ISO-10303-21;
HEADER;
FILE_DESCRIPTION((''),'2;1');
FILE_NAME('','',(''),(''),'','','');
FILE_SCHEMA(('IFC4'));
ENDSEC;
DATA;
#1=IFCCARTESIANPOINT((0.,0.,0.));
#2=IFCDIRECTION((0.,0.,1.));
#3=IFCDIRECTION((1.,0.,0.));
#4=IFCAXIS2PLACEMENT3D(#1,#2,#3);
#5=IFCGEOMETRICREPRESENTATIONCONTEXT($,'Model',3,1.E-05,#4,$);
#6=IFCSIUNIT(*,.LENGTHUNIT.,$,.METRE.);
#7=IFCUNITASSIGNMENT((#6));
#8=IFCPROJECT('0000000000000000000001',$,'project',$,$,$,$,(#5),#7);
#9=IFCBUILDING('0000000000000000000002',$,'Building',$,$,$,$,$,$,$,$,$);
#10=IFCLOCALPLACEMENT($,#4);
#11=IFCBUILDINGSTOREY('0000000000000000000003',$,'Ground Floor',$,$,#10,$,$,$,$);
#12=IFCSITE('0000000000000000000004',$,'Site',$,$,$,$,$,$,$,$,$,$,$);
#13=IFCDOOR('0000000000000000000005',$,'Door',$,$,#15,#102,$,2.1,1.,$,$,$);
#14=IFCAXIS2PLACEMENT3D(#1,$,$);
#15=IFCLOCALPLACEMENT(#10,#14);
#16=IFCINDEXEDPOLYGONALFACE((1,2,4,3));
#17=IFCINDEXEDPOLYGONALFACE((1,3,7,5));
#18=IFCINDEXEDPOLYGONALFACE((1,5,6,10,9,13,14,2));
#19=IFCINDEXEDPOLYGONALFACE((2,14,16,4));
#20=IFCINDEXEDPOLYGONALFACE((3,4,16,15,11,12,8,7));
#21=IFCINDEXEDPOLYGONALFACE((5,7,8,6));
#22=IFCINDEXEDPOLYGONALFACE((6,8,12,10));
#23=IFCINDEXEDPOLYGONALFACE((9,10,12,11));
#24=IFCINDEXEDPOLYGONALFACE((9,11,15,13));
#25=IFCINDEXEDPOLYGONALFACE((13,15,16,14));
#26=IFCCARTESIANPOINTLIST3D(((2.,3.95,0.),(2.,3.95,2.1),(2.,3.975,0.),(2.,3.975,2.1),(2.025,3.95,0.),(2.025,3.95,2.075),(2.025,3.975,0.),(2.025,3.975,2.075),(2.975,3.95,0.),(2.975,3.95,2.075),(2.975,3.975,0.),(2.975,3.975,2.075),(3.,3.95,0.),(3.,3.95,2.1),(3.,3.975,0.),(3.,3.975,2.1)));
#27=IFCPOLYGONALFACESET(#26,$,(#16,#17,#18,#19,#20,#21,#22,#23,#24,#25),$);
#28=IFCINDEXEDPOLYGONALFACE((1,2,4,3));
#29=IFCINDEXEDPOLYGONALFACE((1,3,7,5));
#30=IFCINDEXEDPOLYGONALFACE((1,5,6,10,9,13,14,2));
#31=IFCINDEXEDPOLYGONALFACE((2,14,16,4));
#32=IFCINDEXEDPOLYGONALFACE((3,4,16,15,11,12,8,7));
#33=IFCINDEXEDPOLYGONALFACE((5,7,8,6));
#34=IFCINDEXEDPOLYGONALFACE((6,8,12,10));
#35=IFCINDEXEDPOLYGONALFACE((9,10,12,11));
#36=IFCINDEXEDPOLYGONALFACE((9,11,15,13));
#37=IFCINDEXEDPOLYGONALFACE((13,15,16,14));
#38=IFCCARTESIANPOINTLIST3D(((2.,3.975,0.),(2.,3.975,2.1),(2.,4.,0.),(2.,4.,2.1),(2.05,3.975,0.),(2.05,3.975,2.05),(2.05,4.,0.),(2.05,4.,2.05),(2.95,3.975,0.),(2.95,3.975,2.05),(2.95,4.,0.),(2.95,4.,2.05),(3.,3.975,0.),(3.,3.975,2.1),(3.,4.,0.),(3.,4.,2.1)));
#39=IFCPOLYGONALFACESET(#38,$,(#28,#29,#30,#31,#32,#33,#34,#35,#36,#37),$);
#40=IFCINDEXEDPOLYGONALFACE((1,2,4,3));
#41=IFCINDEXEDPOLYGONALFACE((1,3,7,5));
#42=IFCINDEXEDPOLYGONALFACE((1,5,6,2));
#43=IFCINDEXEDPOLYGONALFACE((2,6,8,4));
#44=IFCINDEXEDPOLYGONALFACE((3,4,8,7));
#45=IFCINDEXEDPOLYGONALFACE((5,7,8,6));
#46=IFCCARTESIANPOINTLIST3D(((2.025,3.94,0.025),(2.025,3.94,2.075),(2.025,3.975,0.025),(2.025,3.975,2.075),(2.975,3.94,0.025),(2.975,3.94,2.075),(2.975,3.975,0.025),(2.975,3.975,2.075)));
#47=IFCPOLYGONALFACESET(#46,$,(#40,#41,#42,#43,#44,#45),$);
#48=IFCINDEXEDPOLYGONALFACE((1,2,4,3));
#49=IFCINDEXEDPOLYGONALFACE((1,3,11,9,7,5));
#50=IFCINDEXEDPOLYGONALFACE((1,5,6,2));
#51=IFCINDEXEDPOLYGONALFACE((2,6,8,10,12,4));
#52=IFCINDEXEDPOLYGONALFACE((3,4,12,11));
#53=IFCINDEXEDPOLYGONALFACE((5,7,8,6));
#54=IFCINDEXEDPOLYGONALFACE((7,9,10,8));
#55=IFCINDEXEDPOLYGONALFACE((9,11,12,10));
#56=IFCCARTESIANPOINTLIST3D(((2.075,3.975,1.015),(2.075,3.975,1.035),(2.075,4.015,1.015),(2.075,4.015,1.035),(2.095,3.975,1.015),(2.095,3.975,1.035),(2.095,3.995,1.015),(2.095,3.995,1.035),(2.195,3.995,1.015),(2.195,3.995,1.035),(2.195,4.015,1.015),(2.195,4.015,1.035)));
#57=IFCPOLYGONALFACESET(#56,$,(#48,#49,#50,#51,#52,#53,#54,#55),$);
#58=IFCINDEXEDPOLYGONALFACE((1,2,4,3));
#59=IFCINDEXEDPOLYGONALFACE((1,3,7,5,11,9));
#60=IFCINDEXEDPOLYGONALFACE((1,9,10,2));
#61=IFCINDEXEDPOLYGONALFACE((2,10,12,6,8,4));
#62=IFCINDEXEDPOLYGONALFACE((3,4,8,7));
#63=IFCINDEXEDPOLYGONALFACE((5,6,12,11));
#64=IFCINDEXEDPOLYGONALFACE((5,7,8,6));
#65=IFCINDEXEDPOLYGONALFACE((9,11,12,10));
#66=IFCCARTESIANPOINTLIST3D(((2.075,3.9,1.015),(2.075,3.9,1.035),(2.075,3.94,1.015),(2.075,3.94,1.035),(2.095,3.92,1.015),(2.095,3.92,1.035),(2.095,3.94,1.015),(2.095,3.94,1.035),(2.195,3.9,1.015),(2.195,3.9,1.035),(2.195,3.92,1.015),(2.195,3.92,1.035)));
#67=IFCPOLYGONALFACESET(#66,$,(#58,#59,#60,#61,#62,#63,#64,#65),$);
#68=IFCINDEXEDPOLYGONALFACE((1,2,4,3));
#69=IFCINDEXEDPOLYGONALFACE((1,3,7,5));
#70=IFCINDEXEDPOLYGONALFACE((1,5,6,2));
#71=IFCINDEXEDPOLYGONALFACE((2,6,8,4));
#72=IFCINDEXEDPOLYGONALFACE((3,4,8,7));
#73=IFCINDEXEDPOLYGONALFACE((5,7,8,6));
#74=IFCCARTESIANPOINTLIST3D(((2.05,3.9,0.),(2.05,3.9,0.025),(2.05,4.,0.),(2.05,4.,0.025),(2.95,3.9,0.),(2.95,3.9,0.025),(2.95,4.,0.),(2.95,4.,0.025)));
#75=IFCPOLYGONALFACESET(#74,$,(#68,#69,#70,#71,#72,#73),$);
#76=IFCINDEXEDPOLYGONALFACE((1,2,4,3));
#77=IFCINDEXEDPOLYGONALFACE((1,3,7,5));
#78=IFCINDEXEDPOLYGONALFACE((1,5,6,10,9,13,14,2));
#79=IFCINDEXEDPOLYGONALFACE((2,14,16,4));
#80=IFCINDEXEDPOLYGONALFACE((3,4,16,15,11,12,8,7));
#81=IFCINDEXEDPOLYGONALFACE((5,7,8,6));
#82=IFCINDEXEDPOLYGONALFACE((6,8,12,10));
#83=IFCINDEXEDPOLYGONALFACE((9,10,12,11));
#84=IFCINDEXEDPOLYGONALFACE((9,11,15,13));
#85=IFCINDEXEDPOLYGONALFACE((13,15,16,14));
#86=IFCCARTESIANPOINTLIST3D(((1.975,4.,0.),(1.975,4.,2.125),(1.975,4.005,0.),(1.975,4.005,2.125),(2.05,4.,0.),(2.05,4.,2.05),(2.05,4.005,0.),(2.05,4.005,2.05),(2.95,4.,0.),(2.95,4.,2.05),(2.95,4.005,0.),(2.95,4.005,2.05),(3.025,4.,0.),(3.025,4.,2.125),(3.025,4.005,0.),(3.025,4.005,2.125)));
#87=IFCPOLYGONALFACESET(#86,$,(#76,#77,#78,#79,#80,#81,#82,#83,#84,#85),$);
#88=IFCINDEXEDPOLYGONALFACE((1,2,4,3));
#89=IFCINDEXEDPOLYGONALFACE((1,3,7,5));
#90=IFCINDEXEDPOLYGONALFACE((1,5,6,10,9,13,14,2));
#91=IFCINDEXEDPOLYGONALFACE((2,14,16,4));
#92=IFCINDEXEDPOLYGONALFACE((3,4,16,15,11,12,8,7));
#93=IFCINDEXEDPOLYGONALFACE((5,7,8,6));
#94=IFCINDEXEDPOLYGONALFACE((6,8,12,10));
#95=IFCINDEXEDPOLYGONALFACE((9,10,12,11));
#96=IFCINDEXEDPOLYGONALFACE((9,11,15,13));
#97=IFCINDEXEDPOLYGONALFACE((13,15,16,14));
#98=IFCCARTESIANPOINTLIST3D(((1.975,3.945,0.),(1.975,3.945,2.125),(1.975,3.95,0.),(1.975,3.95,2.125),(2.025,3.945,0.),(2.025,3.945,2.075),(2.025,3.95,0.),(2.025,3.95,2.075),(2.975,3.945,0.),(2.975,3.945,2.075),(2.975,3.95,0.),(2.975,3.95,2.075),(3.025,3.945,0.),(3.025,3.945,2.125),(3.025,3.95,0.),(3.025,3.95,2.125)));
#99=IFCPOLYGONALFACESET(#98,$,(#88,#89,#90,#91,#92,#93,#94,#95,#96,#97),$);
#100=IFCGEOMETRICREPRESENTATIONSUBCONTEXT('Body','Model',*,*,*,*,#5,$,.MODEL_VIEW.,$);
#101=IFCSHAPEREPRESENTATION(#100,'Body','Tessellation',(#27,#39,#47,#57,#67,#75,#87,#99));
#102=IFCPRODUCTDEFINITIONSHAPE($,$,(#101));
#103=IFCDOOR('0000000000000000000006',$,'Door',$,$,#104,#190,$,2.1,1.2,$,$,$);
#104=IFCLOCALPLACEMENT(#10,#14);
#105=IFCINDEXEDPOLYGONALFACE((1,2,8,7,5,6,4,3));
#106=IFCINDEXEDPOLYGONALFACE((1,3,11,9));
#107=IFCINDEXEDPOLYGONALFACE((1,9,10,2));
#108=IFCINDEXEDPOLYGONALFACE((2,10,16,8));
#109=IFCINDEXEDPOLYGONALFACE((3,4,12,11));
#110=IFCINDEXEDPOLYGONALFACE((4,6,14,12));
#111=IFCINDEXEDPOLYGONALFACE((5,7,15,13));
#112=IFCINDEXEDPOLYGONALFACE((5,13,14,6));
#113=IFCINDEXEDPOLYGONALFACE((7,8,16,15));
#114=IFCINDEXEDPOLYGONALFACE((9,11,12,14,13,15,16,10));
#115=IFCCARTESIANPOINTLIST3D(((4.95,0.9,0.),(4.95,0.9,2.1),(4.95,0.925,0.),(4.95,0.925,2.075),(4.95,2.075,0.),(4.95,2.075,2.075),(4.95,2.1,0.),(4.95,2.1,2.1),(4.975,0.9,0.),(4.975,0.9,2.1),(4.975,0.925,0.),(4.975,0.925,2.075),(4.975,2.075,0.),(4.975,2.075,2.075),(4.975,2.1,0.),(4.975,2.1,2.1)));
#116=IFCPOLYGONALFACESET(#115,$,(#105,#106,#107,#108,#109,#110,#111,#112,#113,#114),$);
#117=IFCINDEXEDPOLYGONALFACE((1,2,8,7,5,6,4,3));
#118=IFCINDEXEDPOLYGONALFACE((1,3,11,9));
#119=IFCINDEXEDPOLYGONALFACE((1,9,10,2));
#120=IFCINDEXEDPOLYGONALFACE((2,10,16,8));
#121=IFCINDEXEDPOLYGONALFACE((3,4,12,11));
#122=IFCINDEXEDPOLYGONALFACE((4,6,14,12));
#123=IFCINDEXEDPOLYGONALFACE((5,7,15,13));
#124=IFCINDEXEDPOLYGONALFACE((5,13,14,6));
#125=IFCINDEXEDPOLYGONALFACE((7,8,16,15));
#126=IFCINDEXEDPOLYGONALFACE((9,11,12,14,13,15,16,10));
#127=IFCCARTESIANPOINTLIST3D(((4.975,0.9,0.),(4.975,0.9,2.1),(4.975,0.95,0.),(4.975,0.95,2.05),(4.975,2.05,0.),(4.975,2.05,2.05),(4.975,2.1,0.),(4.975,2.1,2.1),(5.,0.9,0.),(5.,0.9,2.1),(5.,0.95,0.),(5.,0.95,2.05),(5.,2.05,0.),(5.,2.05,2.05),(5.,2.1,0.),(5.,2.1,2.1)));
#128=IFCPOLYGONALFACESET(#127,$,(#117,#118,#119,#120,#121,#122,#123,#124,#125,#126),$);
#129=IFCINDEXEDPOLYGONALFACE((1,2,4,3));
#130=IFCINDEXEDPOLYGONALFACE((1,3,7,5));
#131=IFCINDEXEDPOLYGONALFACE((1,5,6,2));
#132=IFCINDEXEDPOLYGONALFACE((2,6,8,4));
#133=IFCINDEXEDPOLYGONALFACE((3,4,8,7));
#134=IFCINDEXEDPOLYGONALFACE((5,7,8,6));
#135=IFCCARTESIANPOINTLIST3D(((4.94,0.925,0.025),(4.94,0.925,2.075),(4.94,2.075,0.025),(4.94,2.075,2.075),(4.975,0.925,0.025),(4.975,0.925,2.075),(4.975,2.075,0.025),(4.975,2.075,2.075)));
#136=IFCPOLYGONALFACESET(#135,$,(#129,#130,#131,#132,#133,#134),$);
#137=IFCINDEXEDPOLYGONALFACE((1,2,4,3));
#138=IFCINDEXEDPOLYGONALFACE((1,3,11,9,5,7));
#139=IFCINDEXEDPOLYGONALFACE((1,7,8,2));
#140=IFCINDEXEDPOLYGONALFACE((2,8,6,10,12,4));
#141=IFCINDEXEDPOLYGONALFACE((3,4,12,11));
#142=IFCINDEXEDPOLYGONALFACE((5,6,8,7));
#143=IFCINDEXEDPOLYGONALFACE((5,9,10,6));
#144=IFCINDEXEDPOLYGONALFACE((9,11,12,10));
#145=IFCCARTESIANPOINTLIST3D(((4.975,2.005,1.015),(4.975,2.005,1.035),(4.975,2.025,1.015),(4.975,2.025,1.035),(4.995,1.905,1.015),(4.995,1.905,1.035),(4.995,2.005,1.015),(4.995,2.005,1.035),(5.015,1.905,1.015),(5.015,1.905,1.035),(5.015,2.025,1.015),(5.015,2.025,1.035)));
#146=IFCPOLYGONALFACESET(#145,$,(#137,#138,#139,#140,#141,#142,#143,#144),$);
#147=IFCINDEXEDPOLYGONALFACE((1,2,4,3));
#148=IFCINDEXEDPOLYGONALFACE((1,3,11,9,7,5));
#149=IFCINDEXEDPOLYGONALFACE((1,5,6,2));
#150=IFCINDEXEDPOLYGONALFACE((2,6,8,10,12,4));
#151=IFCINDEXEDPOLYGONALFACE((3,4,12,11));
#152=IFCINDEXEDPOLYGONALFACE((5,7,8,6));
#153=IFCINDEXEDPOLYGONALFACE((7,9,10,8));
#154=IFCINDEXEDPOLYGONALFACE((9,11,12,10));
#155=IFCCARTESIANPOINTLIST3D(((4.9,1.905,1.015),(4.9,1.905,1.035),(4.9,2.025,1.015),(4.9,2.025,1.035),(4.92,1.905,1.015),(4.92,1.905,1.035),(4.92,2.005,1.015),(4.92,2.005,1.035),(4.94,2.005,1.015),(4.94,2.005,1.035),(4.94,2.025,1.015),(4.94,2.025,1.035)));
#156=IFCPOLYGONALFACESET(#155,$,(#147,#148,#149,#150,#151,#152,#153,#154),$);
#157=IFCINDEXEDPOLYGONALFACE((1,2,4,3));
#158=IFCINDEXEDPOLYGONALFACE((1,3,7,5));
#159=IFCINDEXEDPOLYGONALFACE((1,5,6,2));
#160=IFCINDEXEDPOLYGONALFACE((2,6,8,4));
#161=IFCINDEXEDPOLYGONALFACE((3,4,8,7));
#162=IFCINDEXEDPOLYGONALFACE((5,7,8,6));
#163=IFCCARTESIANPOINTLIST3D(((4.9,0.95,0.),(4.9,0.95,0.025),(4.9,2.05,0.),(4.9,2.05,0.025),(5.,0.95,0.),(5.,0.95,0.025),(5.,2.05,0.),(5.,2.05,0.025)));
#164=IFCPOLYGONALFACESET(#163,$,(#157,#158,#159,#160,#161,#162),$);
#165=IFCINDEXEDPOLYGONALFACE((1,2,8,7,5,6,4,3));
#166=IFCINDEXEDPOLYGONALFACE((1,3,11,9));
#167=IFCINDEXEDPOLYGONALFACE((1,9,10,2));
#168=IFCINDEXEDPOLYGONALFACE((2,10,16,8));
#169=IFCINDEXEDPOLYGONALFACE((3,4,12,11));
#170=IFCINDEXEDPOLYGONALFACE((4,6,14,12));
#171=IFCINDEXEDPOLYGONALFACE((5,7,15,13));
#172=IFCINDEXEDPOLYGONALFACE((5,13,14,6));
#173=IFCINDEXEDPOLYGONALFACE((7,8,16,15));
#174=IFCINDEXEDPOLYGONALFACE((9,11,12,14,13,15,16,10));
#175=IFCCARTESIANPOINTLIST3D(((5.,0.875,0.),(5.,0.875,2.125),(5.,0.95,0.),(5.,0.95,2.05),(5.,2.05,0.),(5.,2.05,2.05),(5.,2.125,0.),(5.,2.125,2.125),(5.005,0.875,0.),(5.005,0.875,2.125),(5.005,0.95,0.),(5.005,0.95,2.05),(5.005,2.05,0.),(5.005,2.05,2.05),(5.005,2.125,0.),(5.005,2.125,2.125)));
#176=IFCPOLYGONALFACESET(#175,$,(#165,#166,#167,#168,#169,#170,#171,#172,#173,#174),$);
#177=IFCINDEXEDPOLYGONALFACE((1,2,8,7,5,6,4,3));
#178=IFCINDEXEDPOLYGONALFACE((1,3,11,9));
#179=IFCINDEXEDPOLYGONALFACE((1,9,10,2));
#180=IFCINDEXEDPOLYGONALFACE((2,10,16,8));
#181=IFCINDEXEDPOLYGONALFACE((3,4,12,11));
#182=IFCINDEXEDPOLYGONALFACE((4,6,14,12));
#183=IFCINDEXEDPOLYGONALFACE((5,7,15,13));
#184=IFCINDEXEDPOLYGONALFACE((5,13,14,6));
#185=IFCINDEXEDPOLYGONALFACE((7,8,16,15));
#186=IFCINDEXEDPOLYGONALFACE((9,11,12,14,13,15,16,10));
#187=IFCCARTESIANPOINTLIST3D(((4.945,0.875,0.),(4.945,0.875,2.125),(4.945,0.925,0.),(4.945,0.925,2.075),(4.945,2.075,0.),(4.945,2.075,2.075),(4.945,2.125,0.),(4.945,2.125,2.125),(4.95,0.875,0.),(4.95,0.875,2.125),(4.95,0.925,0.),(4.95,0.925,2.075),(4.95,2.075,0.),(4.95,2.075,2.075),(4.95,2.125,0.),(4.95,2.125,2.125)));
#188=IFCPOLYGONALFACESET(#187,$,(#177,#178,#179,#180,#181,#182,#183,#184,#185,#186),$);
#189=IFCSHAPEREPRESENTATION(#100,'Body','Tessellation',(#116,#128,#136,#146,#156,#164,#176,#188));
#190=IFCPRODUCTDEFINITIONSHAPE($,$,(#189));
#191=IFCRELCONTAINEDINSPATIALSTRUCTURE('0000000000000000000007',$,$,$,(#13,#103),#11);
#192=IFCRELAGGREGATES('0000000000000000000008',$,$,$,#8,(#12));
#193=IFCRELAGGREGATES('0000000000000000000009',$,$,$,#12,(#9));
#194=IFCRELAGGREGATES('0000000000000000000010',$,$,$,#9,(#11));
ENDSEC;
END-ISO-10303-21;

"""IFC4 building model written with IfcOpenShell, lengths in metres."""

from ifc_helpers import new_model, si_unit, frame, origin_with_axes, place, context, subcontext, project, spatial, line, indexed_curve, outline, extrude, element, save


model = new_model("IFC4")

# Units and contexts
model_context = context("Model", 3, precision=1e-05, world=origin_with_axes())
body_context = subcontext(model_context, "Body", "Model", "MODEL_VIEW")
ifc_project = project(units=[si_unit("LENGTHUNIT", "METRE")], contexts=[model_context])

# Site, building, storey
site = spatial("IfcSite", under=ifc_project, Name="Site")
building = spatial("IfcBuilding", under=site, Name="Building")
storey_placement = place(None, origin_with_axes())
storey = spatial("IfcBuildingStorey", under=building, at=storey_placement, Name="Ground Floor")

# Doors
door_1_placement = place(storey_placement, frame((3.0, 4.0, 0.0), z_axis=(0.0, 0.0, 1.0), x_axis=(-1.0, 0.0, 0.0)))
element("IfcDoor", 1, at=door_1_placement, inside=storey, Name="Door", OverallHeight=2.1, OverallWidth=1.0, context=body_context, shape_type="SweptSolid", body=[
    extrude(outline(indexed_curve([(0.0, 0.0), (0.0, 2.1), (1.0, 2.1), (1.0, 0.0), (0.975, 0.0), (0.975, 2.075), (0.025, 2.075), (0.025, 0.0)], segments=[line(1, 2, 3, 4, 5, 6, 7, 8, 1)])), frame((0.0, 0.025, 0.0), z_axis=(0.0, -1.0, 0.0), x_axis=(1.0, 0.0, 0.0)), (0.0, 0.0, -1.0), 0.025),
    extrude(outline(indexed_curve([(0.0, 0.0), (0.0, 2.1), (1.0, 2.1), (1.0, 0.0), (0.95, 0.0), (0.95, 2.05), (0.05, 2.05), (0.05, 0.0)], segments=[line(1, 2, 3, 4, 5, 6, 7, 8, 1)])), frame((0.0, 0.0, 0.0), z_axis=(0.0, -1.0, 0.0), x_axis=(1.0, 0.0, 0.0)), (0.0, 0.0, -1.0), 0.025),
    extrude(outline(indexed_curve([(0.0, 0.0), (0.95, 0.0), (0.95, 0.035), (0.0, 0.035)], segments=[line(1, 2, 3, 4, 1)])), frame((0.025, 0.025, 0.025), z_axis=(0.0, 0.0, 1.0), x_axis=(1.0, 0.0, 0.0)), (0.0, 0.0, 1.0), 2.05),
    extrude(outline(indexed_curve([(0.0, 0.0), (0.0, -0.04), (-0.12, -0.04), (-0.12, -0.02), (-0.02, -0.02), (-0.02, 0.0)], segments=[line(1, 2, 3, 4, 5, 6, 1)])), frame((0.925, 0.025, 1.015), z_axis=(0.0, 0.0, 1.0), x_axis=(1.0, 0.0, 0.0)), (0.0, 0.0, 1.0), 0.02),
    extrude(outline(indexed_curve([(0.0, 0.0), (0.0, 0.04), (-0.12, 0.04), (-0.12, 0.02), (-0.02, 0.02), (-0.02, 0.0)], segments=[line(1, 2, 3, 4, 5, 6, 1)])), frame((0.925, 0.06, 1.015), z_axis=(0.0, 0.0, 1.0), x_axis=(1.0, 0.0, 0.0)), (0.0, 0.0, 1.0), 0.02),
    extrude(outline(indexed_curve([(0.0, 0.0), (0.9, 0.0), (0.9, 0.1), (0.0, 0.1)], segments=[line(1, 2, 3, 4, 1)])), frame((0.05, 0.0, 0.0), z_axis=(0.0, 0.0, 1.0), x_axis=(1.0, 0.0, 0.0)), (0.0, 0.0, 1.0), 0.025),
    extrude(outline(indexed_curve([(0.0, 0.0), (0.0, 2.125), (1.05, 2.125), (1.05, 0.0), (0.975, 0.0), (0.975, 2.05), (0.075, 2.05), (0.075, 0.0)], segments=[line(1, 2, 3, 4, 5, 6, 7, 8, 1)])), frame((-0.025, -0.005, 0.0), z_axis=(0.0, -1.0, 0.0), x_axis=(1.0, 0.0, 0.0)), (0.0, 0.0, -1.0), 0.005),
    extrude(outline(indexed_curve([(0.0, 0.0), (0.0, 2.125), (1.05, 2.125), (1.05, 0.0), (1.0, 0.0), (1.0, 2.075), (0.05, 2.075), (0.05, 0.0)], segments=[line(1, 2, 3, 4, 5, 6, 7, 8, 1)])), frame((-0.025, 0.05, 0.0), z_axis=(0.0, -1.0, 0.0), x_axis=(1.0, 0.0, 0.0)), (0.0, 0.0, -1.0), 0.005),
])
door_2_placement = place(storey_placement, frame((5.0, 0.9, 0.0), z_axis=(0.0, 0.0, 1.0), x_axis=(0.0, 1.0, 0.0)))
element("IfcDoor", 2, at=door_2_placement, inside=storey, Name="Door", OverallHeight=2.1, OverallWidth=1.2, context=body_context, shape_type="SweptSolid", body=[
    extrude(outline(indexed_curve([(0.0, 0.0), (0.0, 2.1), (1.2, 2.1), (1.2, 0.0), (1.175, 0.0), (1.175, 2.075), (0.025, 2.075), (0.025, 0.0)], segments=[line(1, 2, 3, 4, 5, 6, 7, 8, 1)])), frame((0.0, 0.025, 0.0), z_axis=(0.0, -1.0, 0.0), x_axis=(1.0, 0.0, 0.0)), (0.0, 0.0, -1.0), 0.025),
    extrude(outline(indexed_curve([(0.0, 0.0), (0.0, 2.1), (1.2, 2.1), (1.2, 0.0), (1.15, 0.0), (1.15, 2.05), (0.05, 2.05), (0.05, 0.0)], segments=[line(1, 2, 3, 4, 5, 6, 7, 8, 1)])), frame((0.0, 0.0, 0.0), z_axis=(0.0, -1.0, 0.0), x_axis=(1.0, 0.0, 0.0)), (0.0, 0.0, -1.0), 0.025),
    extrude(outline(indexed_curve([(0.0, 0.0), (1.15, 0.0), (1.15, 0.035), (0.0, 0.035)], segments=[line(1, 2, 3, 4, 1)])), frame((0.025, 0.025, 0.025), z_axis=(0.0, 0.0, 1.0), x_axis=(1.0, 0.0, 0.0)), (0.0, 0.0, 1.0), 2.05),
    extrude(outline(indexed_curve([(0.0, 0.0), (0.0, -0.04), (-0.12, -0.04), (-0.12, -0.02), (-0.02, -0.02), (-0.02, 0.0)], segments=[line(1, 2, 3, 4, 5, 6, 1)])), frame((1.125, 0.025, 1.015), z_axis=(0.0, 0.0, 1.0), x_axis=(1.0, 0.0, 0.0)), (0.0, 0.0, 1.0), 0.02),
    extrude(outline(indexed_curve([(0.0, 0.0), (0.0, 0.04), (-0.12, 0.04), (-0.12, 0.02), (-0.02, 0.02), (-0.02, 0.0)], segments=[line(1, 2, 3, 4, 5, 6, 1)])), frame((1.125, 0.06, 1.015), z_axis=(0.0, 0.0, 1.0), x_axis=(1.0, 0.0, 0.0)), (0.0, 0.0, 1.0), 0.02),
    extrude(outline(indexed_curve([(0.0, 0.0), (1.1, 0.0), (1.1, 0.1), (0.0, 0.1)], segments=[line(1, 2, 3, 4, 1)])), frame((0.05, 0.0, 0.0), z_axis=(0.0, 0.0, 1.0), x_axis=(1.0, 0.0, 0.0)), (0.0, 0.0, 1.0), 0.025),
    extrude(outline(indexed_curve([(0.0, 0.0), (0.0, 2.125), (1.25, 2.125), (1.25, 0.0), (1.175, 0.0), (1.175, 2.05), (0.075, 2.05), (0.075, 0.0)], segments=[line(1, 2, 3, 4, 5, 6, 7, 8, 1)])), frame((-0.025, -0.005, 0.0), z_axis=(0.0, -1.0, 0.0), x_axis=(1.0, 0.0, 0.0)), (0.0, 0.0, -1.0), 0.005),
    extrude(outline(indexed_curve([(0.0, 0.0), (0.0, 2.125), (1.25, 2.125), (1.25, 0.0), (1.2, 0.0), (1.2, 2.075), (0.05, 2.075), (0.05, 0.0)], segments=[line(1, 2, 3, 4, 5, 6, 7, 8, 1)])), frame((-0.025, 0.05, 0.0), z_axis=(0.0, -1.0, 0.0), x_axis=(1.0, 0.0, 0.0)), (0.0, 0.0, -1.0), 0.005),
])

save(model, "model.ifc")
